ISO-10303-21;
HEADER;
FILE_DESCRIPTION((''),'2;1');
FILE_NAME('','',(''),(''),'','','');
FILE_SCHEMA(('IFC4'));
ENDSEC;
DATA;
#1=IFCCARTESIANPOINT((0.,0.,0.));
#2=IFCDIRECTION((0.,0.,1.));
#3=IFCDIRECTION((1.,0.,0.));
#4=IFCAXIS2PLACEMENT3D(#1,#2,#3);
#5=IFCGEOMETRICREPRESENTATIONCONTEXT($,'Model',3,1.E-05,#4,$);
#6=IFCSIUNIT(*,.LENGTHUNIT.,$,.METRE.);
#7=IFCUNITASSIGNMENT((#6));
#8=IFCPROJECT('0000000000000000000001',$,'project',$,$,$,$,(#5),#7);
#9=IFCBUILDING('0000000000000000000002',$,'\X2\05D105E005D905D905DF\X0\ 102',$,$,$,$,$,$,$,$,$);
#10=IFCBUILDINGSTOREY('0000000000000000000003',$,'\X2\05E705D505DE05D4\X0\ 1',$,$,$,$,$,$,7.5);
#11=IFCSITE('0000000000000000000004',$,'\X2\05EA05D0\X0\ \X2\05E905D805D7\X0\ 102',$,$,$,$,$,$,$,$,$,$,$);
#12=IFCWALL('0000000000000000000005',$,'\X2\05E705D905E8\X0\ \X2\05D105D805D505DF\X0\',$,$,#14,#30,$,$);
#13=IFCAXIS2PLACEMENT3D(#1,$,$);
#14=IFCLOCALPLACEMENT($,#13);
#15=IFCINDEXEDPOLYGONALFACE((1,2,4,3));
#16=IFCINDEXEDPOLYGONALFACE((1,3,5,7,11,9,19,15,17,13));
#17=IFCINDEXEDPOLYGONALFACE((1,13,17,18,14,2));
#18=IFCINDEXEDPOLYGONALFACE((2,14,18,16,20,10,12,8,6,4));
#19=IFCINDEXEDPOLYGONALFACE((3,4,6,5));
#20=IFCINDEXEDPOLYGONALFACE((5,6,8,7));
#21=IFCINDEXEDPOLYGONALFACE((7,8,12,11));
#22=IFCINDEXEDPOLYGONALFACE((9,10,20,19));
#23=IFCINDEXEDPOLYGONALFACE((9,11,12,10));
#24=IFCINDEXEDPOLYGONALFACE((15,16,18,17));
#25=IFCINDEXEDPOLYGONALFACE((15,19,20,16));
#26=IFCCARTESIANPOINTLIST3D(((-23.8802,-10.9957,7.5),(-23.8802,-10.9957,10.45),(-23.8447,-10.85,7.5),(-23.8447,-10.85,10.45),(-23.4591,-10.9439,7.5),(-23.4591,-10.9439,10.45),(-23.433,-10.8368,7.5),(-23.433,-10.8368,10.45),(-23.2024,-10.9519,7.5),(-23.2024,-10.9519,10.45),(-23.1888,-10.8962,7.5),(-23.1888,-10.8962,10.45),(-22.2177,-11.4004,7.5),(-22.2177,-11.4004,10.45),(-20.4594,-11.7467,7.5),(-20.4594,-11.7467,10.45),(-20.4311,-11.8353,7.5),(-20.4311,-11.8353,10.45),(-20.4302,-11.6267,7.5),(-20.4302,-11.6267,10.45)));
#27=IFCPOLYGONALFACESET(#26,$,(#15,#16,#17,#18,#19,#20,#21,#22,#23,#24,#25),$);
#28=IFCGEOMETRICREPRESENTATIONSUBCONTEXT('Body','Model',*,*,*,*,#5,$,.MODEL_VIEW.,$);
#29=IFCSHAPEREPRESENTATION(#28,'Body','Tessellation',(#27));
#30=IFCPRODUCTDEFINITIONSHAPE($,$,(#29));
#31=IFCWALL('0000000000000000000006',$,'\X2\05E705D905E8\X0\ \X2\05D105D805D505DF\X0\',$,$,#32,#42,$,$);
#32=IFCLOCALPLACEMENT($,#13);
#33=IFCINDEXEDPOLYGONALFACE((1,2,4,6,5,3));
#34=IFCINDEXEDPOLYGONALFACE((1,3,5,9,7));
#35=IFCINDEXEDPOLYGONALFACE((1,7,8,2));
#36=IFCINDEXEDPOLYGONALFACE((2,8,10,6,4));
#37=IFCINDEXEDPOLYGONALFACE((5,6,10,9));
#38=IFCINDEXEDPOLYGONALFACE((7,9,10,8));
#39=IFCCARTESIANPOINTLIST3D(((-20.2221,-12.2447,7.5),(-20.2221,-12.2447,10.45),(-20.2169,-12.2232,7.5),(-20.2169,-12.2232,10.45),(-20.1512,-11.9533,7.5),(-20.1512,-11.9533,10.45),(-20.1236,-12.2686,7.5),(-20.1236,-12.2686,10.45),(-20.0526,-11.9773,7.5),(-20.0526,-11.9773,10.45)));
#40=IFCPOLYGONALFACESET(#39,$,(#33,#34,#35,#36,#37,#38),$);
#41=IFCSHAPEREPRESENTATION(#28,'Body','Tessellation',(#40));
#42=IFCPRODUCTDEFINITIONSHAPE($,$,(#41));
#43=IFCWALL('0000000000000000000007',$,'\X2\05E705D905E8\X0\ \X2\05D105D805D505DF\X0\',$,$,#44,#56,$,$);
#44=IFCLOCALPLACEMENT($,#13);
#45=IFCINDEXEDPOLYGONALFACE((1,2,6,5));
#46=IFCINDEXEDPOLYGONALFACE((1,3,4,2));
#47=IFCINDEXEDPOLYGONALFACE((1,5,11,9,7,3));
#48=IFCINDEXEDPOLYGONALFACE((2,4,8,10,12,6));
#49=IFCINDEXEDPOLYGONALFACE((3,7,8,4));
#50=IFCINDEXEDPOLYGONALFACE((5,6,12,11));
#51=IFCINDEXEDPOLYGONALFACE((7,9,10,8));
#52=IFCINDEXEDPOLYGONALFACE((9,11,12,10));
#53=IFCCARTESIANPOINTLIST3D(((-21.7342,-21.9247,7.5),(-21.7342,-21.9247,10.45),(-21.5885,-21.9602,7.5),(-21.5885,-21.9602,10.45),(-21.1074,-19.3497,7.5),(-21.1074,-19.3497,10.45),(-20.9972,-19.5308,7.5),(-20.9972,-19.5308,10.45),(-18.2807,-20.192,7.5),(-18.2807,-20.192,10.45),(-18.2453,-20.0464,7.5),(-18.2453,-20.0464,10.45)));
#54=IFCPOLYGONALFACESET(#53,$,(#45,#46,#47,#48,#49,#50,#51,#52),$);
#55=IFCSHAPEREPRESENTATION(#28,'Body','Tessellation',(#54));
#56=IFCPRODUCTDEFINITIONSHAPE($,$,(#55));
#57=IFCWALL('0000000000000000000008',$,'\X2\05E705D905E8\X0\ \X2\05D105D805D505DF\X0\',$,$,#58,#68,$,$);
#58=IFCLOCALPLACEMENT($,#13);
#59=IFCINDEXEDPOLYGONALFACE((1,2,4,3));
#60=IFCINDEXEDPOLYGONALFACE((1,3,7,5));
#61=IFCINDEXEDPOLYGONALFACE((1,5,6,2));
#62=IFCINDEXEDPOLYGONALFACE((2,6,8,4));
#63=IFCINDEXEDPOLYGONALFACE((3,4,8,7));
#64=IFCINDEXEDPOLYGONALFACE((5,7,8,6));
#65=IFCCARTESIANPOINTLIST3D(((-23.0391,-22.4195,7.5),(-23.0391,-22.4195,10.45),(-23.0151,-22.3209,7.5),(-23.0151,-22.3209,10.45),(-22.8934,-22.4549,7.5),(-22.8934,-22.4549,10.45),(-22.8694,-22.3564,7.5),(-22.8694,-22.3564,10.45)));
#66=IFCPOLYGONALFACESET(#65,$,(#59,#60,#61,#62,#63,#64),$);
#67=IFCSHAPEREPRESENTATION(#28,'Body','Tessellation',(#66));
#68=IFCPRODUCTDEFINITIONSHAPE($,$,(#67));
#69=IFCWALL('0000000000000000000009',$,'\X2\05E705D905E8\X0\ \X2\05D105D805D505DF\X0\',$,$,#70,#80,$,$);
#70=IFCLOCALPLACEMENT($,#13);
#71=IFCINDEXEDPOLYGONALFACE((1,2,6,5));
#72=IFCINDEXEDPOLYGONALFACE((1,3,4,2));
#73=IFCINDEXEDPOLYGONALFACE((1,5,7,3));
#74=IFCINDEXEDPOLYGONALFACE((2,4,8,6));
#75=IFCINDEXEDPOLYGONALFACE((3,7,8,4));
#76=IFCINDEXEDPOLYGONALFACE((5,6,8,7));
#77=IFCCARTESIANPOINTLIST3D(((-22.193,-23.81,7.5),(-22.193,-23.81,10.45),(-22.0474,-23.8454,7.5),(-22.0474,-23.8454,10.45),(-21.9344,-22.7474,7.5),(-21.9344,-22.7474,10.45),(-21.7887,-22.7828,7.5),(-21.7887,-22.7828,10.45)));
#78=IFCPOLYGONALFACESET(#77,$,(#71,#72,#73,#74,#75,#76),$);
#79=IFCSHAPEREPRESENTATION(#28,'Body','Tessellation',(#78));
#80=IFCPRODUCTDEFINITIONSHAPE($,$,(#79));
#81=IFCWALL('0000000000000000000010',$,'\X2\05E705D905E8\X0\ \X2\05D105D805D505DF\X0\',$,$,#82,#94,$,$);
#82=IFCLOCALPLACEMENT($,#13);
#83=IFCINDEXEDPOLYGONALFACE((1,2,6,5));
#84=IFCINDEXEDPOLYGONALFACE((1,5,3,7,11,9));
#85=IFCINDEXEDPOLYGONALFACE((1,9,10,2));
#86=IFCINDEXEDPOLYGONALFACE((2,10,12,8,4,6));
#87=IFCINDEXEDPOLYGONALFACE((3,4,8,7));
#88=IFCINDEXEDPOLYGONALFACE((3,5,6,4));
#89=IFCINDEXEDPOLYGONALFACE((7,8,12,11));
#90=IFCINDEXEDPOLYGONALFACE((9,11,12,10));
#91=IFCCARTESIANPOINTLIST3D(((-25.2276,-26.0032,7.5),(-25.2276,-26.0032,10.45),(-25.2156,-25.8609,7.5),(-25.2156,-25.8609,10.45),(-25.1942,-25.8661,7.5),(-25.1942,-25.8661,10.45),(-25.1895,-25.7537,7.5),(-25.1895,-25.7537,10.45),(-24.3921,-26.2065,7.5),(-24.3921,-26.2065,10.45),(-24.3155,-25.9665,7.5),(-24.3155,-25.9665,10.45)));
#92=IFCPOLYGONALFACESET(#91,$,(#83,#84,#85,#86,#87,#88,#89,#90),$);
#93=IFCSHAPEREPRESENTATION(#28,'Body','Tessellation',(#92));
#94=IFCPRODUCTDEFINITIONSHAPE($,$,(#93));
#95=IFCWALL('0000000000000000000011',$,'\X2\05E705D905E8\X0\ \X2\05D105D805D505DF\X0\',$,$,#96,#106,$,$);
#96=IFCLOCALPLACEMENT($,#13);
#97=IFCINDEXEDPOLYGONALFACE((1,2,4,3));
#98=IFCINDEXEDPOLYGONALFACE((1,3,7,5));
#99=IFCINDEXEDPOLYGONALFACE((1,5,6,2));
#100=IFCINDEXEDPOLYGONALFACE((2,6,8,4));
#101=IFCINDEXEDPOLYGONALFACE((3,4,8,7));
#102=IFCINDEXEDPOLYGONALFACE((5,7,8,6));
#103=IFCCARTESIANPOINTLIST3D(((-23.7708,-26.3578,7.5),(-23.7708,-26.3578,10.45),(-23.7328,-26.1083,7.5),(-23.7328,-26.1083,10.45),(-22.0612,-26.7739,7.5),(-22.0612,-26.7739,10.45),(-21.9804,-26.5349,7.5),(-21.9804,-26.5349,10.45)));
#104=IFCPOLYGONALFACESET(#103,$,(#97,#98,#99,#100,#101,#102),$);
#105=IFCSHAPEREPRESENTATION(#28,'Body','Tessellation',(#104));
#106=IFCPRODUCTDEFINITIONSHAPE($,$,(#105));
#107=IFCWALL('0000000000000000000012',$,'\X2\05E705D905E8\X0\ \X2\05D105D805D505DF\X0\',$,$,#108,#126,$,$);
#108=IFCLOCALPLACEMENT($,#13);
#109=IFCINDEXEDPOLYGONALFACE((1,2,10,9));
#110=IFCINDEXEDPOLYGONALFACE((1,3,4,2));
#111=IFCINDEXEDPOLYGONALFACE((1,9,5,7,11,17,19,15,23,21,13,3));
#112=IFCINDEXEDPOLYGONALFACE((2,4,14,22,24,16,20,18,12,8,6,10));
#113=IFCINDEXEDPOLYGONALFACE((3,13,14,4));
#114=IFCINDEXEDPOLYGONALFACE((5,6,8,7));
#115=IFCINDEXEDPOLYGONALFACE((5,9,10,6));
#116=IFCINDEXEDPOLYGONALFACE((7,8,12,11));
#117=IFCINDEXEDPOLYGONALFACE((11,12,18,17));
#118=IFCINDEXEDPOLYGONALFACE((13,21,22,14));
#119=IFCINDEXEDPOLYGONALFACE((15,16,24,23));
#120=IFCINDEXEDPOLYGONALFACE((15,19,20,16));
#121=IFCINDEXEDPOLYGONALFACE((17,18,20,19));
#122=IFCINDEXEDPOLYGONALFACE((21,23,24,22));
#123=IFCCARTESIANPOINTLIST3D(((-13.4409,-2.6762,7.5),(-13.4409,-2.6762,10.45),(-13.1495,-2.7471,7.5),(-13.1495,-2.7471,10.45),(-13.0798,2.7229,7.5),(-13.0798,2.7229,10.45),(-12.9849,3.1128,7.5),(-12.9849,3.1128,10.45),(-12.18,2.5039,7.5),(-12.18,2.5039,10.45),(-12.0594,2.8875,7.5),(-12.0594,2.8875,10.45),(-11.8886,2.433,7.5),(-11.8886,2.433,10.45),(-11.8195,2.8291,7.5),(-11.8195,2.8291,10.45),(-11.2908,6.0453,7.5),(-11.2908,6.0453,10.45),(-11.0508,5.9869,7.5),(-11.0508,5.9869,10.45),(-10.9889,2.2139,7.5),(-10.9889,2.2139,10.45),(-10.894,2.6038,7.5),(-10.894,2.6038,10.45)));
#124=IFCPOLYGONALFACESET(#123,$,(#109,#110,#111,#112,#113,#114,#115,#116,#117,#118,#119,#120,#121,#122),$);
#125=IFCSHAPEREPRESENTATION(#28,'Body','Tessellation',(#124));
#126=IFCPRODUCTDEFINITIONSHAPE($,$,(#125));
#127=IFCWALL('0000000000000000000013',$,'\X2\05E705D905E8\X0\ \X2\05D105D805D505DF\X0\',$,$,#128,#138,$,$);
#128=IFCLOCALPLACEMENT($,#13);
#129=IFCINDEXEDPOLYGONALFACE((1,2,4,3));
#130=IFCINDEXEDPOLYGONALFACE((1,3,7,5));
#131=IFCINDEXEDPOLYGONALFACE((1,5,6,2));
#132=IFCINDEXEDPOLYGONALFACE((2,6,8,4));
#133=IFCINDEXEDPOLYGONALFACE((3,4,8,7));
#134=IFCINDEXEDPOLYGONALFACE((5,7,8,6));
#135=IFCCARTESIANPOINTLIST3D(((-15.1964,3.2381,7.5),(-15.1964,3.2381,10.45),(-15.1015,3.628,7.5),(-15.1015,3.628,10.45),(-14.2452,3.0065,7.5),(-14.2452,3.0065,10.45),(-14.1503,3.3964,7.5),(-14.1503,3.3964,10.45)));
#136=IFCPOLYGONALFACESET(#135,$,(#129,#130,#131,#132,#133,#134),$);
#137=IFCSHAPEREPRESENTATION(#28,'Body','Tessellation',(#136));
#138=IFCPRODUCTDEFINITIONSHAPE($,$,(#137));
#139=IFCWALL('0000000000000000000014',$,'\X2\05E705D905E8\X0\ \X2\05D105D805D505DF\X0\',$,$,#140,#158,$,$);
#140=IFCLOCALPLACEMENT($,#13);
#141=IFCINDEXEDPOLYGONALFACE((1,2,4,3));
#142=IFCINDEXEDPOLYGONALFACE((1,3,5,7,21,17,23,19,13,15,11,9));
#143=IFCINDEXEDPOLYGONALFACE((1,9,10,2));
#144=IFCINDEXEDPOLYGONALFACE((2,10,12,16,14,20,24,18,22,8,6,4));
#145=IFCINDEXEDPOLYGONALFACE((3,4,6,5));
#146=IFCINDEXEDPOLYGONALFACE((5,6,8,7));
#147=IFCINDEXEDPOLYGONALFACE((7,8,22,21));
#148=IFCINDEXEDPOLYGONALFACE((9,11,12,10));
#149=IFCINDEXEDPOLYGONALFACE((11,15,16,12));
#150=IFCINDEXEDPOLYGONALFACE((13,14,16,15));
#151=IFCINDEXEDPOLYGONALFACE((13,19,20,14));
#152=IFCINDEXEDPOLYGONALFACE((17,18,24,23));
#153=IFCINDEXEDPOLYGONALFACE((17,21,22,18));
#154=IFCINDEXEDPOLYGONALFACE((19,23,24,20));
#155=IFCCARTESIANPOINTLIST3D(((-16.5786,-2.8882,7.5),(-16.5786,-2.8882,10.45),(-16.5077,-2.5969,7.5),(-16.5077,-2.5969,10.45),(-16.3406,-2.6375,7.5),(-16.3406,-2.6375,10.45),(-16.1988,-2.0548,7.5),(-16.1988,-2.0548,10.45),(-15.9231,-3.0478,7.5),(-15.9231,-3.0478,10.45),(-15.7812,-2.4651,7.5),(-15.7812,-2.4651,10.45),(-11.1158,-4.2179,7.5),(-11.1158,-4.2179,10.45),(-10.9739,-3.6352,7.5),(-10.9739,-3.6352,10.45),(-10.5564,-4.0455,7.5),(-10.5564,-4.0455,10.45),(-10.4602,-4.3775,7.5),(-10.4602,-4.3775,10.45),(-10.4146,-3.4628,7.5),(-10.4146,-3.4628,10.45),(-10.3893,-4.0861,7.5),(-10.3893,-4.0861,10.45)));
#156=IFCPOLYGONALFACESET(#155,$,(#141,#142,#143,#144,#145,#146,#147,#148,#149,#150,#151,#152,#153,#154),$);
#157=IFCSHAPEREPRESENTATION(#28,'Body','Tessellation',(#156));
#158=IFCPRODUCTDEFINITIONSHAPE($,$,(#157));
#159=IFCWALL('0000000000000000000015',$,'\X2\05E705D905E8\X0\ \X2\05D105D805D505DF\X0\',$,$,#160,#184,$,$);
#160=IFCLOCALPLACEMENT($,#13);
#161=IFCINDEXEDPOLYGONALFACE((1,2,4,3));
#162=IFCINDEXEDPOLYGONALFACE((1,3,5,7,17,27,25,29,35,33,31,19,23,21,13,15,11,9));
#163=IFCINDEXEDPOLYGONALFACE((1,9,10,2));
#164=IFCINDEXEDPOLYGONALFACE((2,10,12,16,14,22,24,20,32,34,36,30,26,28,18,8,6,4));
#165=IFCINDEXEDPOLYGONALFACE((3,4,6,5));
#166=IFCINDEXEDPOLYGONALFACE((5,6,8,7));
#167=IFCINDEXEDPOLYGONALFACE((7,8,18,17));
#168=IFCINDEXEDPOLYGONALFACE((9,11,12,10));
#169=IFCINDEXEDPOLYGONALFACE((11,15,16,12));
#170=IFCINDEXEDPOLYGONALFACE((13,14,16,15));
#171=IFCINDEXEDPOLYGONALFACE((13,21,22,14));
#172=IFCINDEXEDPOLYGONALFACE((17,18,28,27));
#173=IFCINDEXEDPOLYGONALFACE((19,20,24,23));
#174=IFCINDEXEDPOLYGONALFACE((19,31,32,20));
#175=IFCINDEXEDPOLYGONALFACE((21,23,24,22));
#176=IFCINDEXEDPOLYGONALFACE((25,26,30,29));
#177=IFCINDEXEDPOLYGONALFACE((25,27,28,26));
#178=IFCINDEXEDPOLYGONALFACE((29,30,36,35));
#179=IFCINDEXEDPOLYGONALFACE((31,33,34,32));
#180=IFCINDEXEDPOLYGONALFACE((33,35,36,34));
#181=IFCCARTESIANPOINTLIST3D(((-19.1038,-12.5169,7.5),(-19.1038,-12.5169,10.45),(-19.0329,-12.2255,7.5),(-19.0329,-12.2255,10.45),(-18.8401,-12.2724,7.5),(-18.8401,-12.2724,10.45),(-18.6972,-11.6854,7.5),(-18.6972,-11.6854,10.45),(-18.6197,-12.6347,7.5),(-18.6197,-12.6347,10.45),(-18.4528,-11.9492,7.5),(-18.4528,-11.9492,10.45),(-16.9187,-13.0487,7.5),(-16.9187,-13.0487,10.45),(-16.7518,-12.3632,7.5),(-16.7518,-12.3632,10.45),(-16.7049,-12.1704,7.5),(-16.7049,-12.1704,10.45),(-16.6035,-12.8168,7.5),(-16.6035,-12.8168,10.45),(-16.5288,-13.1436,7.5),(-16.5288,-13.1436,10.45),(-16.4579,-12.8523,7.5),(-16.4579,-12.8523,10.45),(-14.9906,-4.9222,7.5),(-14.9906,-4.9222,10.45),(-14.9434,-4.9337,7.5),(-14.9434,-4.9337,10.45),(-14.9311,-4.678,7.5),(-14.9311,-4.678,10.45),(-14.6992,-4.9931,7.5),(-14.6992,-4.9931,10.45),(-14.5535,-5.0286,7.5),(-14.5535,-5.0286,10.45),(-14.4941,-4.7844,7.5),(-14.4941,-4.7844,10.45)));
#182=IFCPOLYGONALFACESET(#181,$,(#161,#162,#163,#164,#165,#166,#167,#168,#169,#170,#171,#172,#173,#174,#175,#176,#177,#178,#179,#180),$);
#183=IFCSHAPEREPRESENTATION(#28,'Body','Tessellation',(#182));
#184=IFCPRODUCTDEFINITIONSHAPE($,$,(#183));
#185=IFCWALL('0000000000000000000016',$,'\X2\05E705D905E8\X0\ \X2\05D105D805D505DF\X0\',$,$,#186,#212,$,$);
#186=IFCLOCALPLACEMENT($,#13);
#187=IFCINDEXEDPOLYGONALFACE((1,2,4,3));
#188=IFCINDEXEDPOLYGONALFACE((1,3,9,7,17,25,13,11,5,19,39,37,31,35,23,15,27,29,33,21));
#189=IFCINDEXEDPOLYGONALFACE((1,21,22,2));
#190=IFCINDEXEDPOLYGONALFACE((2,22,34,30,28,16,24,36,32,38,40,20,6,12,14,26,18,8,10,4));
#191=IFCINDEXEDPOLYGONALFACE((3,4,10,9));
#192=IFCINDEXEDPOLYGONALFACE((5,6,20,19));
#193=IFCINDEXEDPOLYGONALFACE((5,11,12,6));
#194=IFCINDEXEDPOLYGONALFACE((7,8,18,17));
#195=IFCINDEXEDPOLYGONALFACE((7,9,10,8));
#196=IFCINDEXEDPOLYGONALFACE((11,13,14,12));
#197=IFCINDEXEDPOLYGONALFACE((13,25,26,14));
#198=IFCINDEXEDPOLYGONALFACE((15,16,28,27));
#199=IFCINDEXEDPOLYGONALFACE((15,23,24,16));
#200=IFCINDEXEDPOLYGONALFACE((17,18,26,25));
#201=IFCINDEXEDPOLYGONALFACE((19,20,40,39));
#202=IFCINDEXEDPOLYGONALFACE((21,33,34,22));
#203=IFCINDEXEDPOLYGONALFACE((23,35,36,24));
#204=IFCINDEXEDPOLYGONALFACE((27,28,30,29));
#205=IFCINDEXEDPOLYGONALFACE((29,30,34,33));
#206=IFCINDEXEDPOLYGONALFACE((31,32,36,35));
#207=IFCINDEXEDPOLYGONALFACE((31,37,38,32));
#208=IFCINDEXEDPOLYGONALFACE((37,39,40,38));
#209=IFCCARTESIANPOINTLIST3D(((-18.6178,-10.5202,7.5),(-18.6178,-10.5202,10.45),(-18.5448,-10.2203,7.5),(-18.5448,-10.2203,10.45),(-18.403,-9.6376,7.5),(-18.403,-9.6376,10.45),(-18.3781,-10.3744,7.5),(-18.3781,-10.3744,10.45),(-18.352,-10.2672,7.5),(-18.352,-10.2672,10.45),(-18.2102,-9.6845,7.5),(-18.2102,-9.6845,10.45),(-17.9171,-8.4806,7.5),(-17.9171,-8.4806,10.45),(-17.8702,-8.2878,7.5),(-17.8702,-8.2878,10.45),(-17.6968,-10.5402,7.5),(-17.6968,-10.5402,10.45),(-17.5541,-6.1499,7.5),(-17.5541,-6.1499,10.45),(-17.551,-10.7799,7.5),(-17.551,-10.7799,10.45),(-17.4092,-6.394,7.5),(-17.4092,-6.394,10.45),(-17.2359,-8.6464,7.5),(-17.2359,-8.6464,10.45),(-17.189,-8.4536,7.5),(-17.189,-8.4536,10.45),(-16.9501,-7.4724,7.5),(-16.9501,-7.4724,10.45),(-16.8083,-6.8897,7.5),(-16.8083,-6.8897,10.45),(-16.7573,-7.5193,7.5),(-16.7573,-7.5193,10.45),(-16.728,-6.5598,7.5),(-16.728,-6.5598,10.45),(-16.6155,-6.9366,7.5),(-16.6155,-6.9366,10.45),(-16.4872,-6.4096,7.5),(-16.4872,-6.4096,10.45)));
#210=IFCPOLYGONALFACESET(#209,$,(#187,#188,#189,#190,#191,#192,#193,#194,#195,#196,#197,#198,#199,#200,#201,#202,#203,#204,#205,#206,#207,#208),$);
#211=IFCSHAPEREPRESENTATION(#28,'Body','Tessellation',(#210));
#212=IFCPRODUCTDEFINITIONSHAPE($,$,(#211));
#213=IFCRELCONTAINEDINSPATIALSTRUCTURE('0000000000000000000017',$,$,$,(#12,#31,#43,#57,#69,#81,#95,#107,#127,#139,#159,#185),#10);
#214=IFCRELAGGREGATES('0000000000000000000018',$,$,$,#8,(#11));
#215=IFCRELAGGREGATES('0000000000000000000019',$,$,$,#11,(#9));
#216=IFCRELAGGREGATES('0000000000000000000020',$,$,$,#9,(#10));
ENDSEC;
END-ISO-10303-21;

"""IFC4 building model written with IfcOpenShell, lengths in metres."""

from ifc_helpers import new_model, si_unit, frame, origin_with_axes, context, subcontext, project, spatial, polyline, outline, extrude, element, save


model = new_model("IFC4")

# Units and contexts
model_context = context("Model", 3, precision=1e-05, world=origin_with_axes())
body_context = subcontext(model_context, "Body", "Model", "MODEL_VIEW")
ifc_project = project(units=[si_unit("LENGTHUNIT", "METRE")], contexts=[model_context])

# Site, building, storey
site = spatial("IfcSite", under=ifc_project, Name="תא שטח 102")
building = spatial("IfcBuilding", under=site, Name="בניין 102")
storey = spatial("IfcBuildingStorey", under=building, Name="קומה 1", Elevation=7.5)

# Walls
element("IfcWall", 1, inside=storey, Name="קיר בטון", context=body_context, shape_type="SweptSolid", body=[
    extrude(outline(polyline([(-23.8802, -10.9957), (-22.2177, -11.4004), (-20.4311, -11.8353), (-20.4594, -11.7467), (-20.4302, -11.6267), (-23.2024, -10.9519), (-23.1888, -10.8962), (-23.433, -10.8368), (-23.4591, -10.9439), (-23.8447, -10.85), (-23.8802, -10.9957)])), frame((0.0, 0.0, 7.5)), (0.0, 0.0, 1.0), 2.95),
])
element("IfcWall", 2, inside=storey, Name="קיר בטון", context=body_context, shape_type="SweptSolid", body=[
    extrude(outline(polyline([(-20.0526, -11.9773), (-20.1512, -11.9533), (-20.2169, -12.2232), (-20.2221, -12.2447), (-20.1236, -12.2686), (-20.0526, -11.9773)])), frame((0.0, 0.0, 7.5)), (0.0, 0.0, 1.0), 2.95),
])
element("IfcWall", 3, inside=storey, Name="קיר בטון", context=body_context, shape_type="SweptSolid", body=[
    extrude(outline(polyline([(-21.5885, -21.9602), (-20.9972, -19.5308), (-18.2807, -20.192), (-18.2453, -20.0464), (-21.1074, -19.3497), (-21.7342, -21.9247), (-21.5885, -21.9602)])), frame((0.0, 0.0, 7.5)), (0.0, 0.0, 1.0), 2.95),
])
element("IfcWall", 4, inside=storey, Name="קיר בטון", context=body_context, shape_type="SweptSolid", body=[
    extrude(outline(polyline([(-23.0151, -22.3209), (-23.0391, -22.4195), (-22.8934, -22.4549), (-22.8694, -22.3564), (-23.0151, -22.3209)])), frame((0.0, 0.0, 7.5)), (0.0, 0.0, 1.0), 2.95),
])
element("IfcWall", 5, inside=storey, Name="קיר בטון", context=body_context, shape_type="SweptSolid", body=[
    extrude(outline(polyline([(-22.193, -23.81), (-22.0474, -23.8454), (-21.7887, -22.7828), (-21.9344, -22.7474), (-22.193, -23.81)])), frame((0.0, 0.0, 7.5)), (0.0, 0.0, 1.0), 2.95),
])
element("IfcWall", 6, inside=storey, Name="קיר בטון", context=body_context, shape_type="SweptSolid", body=[
    extrude(outline(polyline([(-25.1942, -25.8661), (-25.2276, -26.0032), (-24.3921, -26.2065), (-24.3155, -25.9665), (-25.1895, -25.7537), (-25.2156, -25.8609), (-25.1942, -25.8661)])), frame((0.0, 0.0, 7.5)), (0.0, 0.0, 1.0), 2.95),
])
element("IfcWall", 7, inside=storey, Name="קיר בטון", context=body_context, shape_type="SweptSolid", body=[
    extrude(outline(polyline([(-23.7708, -26.3578), (-22.0612, -26.7739), (-21.9804, -26.5349), (-23.7328, -26.1083), (-23.7708, -26.3578)])), frame((0.0, 0.0, 7.5)), (0.0, 0.0, 1.0), 2.95),
])
element("IfcWall", 8, inside=storey, Name="קיר בטון", context=body_context, shape_type="SweptSolid", body=[
    extrude(outline(polyline([(-11.0508, 5.9869), (-11.2908, 6.0453), (-12.0594, 2.8875), (-12.9849, 3.1128), (-13.0798, 2.7229), (-12.18, 2.5039), (-13.4409, -2.6762), (-13.1495, -2.7471), (-11.8886, 2.433), (-10.9889, 2.2139), (-10.894, 2.6038), (-11.8195, 2.8291), (-11.0508, 5.9869)])), frame((0.0, 0.0, 7.5)), (0.0, 0.0, 1.0), 2.95),
])
element("IfcWall", 9, inside=storey, Name="קיר בטון", context=body_context, shape_type="SweptSolid", body=[
    extrude(outline(polyline([(-14.1503, 3.3964), (-15.1015, 3.628), (-15.1964, 3.2381), (-14.2452, 3.0065), (-14.1503, 3.3964)])), frame((0.0, 0.0, 7.5)), (0.0, 0.0, 1.0), 2.95),
])
element("IfcWall", 10, inside=storey, Name="קיר בטון", context=body_context, shape_type="SweptSolid", body=[
    extrude(outline(polyline([(-16.5786, -2.8882), (-15.9231, -3.0478), (-15.7812, -2.4651), (-10.9739, -3.6352), (-11.1158, -4.2179), (-10.4602, -4.3775), (-10.3893, -4.0861), (-10.5564, -4.0455), (-10.4146, -3.4628), (-16.1988, -2.0548), (-16.3406, -2.6375), (-16.5077, -2.5969), (-16.5786, -2.8882)])), frame((0.0, 0.0, 7.5)), (0.0, 0.0, 1.0), 2.95),
])
element("IfcWall", 11, inside=storey, Name="קיר בטון", context=body_context, shape_type="SweptSolid", body=[
    extrude(outline(polyline([(-14.9906, -4.9222), (-14.9434, -4.9337), (-16.7049, -12.1704), (-18.6972, -11.6854), (-18.8401, -12.2724), (-19.0329, -12.2255), (-19.1038, -12.5169), (-18.6197, -12.6347), (-18.4528, -11.9492), (-16.7518, -12.3632), (-16.9187, -13.0487), (-16.5288, -13.1436), (-16.4579, -12.8523), (-16.6035, -12.8168), (-14.6992, -4.9931), (-14.5535, -5.0286), (-14.4941, -4.7844), (-14.9311, -4.678), (-14.9906, -4.9222)])), frame((0.0, 0.0, 7.5)), (0.0, 0.0, 1.0), 2.95),
])
element("IfcWall", 12, inside=storey, Name="קיר בטון", context=body_context, shape_type="SweptSolid", body=[
    extrude(outline(polyline([(-17.9171, -8.4806), (-17.2359, -8.6464), (-17.6968, -10.5402), (-18.3781, -10.3744), (-18.352, -10.2672), (-18.5448, -10.2203), (-18.6178, -10.5202), (-17.551, -10.7799), (-16.7573, -7.5193), (-16.9501, -7.4724), (-17.189, -8.4536), (-17.8702, -8.2878), (-17.4092, -6.394), (-16.728, -6.5598), (-16.8083, -6.8897), (-16.6155, -6.9366), (-16.4872, -6.4096), (-17.5541, -6.1499), (-18.403, -9.6376), (-18.2102, -9.6845), (-17.9171, -8.4806)])), frame((0.0, 0.0, 7.5)), (0.0, 0.0, 1.0), 2.95),
])

save(model, "model.ifc")
